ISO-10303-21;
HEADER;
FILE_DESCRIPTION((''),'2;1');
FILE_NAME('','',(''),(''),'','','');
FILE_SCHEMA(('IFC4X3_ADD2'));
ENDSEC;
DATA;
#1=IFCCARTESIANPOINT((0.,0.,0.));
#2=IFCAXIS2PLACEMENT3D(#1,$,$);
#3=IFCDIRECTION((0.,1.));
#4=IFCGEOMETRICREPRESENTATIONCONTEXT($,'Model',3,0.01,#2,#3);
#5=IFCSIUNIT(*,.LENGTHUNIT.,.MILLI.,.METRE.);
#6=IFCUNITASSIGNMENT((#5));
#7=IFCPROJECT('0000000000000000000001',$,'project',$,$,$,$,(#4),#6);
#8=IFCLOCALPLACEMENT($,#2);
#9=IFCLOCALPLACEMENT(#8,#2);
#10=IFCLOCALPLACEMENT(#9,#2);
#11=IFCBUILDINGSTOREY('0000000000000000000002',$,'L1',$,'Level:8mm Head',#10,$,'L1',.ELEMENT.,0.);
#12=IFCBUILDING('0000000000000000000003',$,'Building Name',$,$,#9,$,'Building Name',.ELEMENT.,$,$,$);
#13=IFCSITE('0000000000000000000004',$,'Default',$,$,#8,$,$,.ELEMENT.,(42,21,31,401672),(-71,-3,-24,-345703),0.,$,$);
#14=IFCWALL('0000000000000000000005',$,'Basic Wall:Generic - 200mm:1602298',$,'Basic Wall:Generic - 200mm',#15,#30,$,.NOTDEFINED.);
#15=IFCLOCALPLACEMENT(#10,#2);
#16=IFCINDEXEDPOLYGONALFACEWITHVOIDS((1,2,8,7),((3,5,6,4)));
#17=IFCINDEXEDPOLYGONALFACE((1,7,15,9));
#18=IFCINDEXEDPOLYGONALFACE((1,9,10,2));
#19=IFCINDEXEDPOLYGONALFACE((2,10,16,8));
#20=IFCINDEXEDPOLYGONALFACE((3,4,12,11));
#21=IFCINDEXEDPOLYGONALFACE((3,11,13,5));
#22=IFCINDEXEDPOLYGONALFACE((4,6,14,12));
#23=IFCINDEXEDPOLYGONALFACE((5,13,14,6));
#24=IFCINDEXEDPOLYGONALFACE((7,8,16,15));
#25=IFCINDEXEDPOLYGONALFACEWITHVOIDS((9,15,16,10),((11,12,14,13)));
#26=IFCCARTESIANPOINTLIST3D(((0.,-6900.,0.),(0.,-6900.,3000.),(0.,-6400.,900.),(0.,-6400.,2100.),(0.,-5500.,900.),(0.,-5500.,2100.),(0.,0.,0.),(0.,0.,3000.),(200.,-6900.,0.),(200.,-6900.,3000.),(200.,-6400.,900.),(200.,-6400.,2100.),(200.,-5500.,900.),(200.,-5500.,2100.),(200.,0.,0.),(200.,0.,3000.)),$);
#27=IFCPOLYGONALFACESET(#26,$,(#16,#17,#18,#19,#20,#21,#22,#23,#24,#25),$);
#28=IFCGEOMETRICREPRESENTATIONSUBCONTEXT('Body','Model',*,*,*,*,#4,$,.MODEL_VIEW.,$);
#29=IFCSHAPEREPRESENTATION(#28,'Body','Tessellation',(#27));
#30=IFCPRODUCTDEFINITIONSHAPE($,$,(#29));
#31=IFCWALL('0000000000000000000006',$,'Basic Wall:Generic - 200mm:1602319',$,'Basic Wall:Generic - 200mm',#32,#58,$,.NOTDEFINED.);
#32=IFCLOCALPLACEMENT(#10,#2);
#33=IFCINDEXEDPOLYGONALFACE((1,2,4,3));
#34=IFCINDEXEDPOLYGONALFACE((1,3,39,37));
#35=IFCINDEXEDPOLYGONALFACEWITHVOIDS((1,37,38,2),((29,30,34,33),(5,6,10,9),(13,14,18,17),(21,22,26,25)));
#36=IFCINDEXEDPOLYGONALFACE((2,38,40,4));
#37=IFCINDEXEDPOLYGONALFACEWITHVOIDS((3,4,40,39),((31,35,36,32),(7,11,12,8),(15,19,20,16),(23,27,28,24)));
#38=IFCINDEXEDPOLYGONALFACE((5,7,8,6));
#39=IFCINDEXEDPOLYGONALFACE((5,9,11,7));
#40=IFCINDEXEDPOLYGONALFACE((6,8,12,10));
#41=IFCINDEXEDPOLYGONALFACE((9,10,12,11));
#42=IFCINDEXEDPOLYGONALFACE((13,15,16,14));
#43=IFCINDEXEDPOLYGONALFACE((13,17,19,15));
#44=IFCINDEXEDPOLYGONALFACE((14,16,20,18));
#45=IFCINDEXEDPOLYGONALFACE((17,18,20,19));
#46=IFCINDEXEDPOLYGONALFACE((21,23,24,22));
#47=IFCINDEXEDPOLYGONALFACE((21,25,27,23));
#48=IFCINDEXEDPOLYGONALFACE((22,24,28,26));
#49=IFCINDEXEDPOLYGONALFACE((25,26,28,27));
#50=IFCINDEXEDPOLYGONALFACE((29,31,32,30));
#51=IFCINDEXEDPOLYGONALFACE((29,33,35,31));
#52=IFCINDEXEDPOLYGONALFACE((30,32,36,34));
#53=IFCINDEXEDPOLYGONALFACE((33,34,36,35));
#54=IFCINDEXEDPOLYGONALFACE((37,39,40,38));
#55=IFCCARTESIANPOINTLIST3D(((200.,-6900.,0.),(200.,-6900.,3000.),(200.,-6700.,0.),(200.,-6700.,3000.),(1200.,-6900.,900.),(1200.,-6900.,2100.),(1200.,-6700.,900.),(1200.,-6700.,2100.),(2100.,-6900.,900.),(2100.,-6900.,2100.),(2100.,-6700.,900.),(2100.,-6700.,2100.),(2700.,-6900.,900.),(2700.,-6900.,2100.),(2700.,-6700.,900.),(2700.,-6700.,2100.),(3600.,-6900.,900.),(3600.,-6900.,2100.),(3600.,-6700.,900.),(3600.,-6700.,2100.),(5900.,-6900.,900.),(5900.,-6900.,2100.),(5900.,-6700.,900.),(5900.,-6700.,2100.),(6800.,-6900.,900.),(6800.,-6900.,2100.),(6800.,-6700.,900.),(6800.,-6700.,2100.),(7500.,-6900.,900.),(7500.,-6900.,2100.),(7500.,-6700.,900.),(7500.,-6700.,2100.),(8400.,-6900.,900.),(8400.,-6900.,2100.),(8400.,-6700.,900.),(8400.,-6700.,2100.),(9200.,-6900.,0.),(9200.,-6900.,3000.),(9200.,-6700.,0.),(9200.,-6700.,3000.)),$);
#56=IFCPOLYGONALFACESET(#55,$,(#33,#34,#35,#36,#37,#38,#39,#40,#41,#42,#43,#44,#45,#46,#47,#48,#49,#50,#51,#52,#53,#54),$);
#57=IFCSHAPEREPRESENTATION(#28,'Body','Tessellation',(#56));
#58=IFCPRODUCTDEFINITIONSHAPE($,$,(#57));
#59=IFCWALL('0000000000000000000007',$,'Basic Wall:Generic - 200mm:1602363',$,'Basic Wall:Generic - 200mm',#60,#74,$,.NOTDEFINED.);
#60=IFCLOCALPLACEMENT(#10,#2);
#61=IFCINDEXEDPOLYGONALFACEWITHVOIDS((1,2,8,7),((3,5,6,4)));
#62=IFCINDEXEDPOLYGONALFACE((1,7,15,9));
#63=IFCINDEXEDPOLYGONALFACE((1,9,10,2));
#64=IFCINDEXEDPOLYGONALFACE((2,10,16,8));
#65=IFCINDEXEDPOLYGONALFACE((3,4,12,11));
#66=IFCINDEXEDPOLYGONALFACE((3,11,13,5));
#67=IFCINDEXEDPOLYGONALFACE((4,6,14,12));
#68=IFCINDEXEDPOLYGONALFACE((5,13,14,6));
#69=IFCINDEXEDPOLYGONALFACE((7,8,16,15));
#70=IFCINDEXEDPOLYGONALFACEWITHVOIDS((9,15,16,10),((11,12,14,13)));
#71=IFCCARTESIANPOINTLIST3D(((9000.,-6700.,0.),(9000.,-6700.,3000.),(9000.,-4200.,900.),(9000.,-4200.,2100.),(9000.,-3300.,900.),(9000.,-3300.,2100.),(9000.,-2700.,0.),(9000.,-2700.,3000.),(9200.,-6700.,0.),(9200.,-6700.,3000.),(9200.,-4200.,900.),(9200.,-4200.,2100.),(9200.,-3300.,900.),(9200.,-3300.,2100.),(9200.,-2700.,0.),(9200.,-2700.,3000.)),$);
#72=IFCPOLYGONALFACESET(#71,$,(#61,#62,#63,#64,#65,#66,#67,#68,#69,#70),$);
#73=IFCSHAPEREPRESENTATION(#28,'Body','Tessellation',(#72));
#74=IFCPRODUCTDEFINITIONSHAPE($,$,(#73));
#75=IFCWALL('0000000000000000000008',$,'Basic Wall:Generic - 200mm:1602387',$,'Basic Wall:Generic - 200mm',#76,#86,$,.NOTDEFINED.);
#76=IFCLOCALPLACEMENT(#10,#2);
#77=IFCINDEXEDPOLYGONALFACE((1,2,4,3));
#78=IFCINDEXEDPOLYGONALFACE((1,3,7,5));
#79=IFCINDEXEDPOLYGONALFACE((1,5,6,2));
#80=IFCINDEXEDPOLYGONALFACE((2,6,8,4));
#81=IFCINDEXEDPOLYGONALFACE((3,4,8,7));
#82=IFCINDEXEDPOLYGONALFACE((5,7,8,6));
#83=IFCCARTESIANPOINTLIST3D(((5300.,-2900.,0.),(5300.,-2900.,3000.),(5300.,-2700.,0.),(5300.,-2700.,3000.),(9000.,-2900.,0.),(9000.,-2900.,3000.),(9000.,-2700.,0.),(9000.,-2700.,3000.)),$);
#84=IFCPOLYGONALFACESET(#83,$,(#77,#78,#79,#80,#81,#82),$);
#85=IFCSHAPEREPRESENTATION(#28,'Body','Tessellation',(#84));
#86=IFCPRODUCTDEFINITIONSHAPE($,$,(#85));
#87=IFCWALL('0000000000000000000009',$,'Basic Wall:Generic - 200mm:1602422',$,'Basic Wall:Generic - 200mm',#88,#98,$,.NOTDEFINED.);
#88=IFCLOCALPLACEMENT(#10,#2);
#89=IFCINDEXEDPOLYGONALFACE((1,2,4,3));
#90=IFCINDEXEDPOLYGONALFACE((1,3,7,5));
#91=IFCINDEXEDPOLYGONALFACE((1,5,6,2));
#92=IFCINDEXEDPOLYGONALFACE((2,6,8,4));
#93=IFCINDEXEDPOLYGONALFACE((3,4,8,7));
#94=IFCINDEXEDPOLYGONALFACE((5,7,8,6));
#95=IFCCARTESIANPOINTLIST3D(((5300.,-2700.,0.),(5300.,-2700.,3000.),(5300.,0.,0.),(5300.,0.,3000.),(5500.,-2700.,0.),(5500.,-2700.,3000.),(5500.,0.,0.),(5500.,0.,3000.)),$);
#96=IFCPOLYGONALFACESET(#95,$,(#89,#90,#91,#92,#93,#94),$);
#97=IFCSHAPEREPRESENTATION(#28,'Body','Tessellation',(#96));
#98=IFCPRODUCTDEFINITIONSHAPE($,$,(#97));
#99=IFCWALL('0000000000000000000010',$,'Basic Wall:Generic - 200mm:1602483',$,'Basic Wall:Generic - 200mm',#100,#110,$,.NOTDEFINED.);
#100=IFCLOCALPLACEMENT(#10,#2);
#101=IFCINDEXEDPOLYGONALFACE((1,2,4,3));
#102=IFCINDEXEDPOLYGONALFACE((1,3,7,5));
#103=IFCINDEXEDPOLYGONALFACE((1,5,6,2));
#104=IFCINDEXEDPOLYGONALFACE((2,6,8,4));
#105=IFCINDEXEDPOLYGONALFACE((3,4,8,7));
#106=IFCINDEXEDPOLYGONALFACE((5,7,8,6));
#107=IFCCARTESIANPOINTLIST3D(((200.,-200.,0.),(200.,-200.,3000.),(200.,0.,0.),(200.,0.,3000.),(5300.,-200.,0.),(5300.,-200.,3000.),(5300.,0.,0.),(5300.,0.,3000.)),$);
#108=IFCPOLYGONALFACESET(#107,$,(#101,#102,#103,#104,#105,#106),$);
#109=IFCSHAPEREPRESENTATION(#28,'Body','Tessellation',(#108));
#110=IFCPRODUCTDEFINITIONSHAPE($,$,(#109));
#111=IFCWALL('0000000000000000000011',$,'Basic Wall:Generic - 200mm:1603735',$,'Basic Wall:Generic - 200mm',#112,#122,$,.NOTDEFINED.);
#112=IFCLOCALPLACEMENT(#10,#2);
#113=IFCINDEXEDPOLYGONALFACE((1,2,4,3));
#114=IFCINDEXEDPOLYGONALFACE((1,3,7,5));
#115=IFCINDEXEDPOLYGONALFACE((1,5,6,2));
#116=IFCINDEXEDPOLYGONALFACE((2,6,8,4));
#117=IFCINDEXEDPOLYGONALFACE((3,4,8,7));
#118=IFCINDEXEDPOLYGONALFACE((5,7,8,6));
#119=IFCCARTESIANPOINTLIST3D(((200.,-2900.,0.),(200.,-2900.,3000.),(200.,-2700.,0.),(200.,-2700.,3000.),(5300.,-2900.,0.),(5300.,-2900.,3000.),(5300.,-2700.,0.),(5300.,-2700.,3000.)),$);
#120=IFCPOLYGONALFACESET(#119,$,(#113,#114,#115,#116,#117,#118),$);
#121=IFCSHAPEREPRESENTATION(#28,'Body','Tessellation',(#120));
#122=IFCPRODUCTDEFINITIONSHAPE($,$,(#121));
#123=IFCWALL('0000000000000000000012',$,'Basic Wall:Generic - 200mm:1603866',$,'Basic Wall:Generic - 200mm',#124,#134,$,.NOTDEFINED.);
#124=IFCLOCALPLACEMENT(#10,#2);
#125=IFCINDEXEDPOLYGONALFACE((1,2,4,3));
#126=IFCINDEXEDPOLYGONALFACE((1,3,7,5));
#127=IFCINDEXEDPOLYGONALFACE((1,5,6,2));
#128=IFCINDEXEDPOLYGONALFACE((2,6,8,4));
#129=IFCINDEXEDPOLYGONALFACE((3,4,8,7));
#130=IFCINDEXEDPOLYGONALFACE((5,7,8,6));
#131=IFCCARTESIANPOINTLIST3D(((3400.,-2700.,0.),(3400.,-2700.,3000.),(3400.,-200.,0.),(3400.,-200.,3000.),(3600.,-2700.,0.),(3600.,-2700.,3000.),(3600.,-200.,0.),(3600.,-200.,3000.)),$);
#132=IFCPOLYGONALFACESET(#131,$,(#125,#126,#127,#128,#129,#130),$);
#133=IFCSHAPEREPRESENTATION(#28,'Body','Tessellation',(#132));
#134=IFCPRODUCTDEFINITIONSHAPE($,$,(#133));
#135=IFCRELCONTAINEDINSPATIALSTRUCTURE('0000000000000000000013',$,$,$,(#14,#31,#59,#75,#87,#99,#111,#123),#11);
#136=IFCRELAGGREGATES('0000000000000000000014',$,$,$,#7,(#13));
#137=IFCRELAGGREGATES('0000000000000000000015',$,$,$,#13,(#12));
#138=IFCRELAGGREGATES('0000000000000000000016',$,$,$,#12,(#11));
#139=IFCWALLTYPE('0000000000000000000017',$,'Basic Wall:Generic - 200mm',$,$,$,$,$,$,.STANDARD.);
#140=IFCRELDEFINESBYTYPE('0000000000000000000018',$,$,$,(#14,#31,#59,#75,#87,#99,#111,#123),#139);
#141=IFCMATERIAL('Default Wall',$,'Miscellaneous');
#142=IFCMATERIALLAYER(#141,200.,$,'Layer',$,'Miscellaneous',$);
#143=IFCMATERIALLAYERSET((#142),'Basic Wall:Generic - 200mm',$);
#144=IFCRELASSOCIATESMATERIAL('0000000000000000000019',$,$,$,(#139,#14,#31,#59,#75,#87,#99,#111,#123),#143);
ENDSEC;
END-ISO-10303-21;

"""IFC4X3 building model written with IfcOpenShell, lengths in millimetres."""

from ifc_helpers import new_model, si_unit, direction, frame, frame_2d, origin, place, context, subcontext, project, spatial, rectangle, extrude, material, layer, layer_set, type_object, element, save


model = new_model("IFC4X3")

# Units and contexts
model_context = context("Model", 3, precision=0.01, world=origin(), true_north=direction((0.0, 1.0)))
body_context = subcontext(model_context, "Body", "Model", "MODEL_VIEW")
ifc_project = project(units=[si_unit("LENGTHUNIT", "METRE", prefix="MILLI")], contexts=[model_context])

# Site, building, storey
site_placement = place(None, origin())
site = spatial("IfcSite", under=ifc_project, at=site_placement, Name="Default", CompositionType="ELEMENT", RefLatitude=(42, 21, 31, 401672), RefLongitude=(-71, -3, -24, -345703), RefElevation=0.0)
building_placement = place(site_placement, origin())
building = spatial("IfcBuilding", under=site, at=building_placement, Name="Building Name", LongName="Building Name", CompositionType="ELEMENT")
storey_placement = place(building_placement, origin())
storey = spatial("IfcBuildingStorey", under=building, at=storey_placement, Name="L1", ObjectType="Level:8mm Head", LongName="L1", CompositionType="ELEMENT", Elevation=0.0)

# Wall, opening
ifc_material = material(Name="Default Wall", Category="Miscellaneous")
ifc_layer = layer(ifc_material, 200.0, Name="Layer", Category="Miscellaneous")
ifc_layer_set = layer_set([ifc_layer], Name="Basic Wall:Generic - 200mm")
wall_type = type_object("IfcWallType", Name="Basic Wall:Generic - 200mm", PredefinedType="STANDARD", material=ifc_layer_set)
wall_1_placement = place(storey_placement, frame((100.0, 0.0, 0.0), z_axis=(0.0, 0.0, 1.0), x_axis=(0.0, -1.0, 0.0)))
wall_1 = element("IfcWall", 1, at=wall_1_placement, inside=storey, type_object=wall_type, material=ifc_layer_set, Name="Basic Wall:Generic - 200mm:1602298", ObjectType="Basic Wall:Generic - 200mm", PredefinedType="NOTDEFINED", context=body_context, shape_type="SweptSolid", body=[
    extrude(rectangle(XDim=6900.0, YDim=200.0, at=frame_2d((3450.0, 0.0), x_axis=(-1.0, 0.0))), origin(), (0.0, 0.0, 1.0), 3000.0),
])
opening_1_placement = place(wall_1_placement, frame((6400.0, 100.0, 900.0)))
element("IfcOpeningElement", 2, at=opening_1_placement, cuts=wall_1, PredefinedType="OPENING", context=body_context, shape_type="SweptSolid", body=[
    extrude(rectangle(XDim=1200.0, YDim=900.0, at=frame_2d((600.0, 450.0), x_axis=(-1.0, 0.0))), frame((0.0, 0.0, 0.0), z_axis=(0.0, -1.0, 0.0), x_axis=(0.0, 0.0, 1.0)), (0.0, 0.0, 1.0), 200.0),
])

# Wall, openings
wall_2_placement = place(storey_placement, frame((200.0, -6800.0, 0.0)))
wall_2 = element("IfcWall", 3, at=wall_2_placement, inside=storey, type_object=wall_type, material=ifc_layer_set, Name="Basic Wall:Generic - 200mm:1602319", ObjectType="Basic Wall:Generic - 200mm", PredefinedType="NOTDEFINED", context=body_context, shape_type="SweptSolid", body=[
    extrude(rectangle(XDim=9000.0, YDim=200.0, at=frame_2d((4500.0, 0.0), x_axis=(-1.0, 0.0))), origin(), (0.0, 0.0, 1.0), 3000.0),
])
opening_2_placement = place(wall_2_placement, frame((1900.0, 100.0, 900.0)))
element("IfcOpeningElement", 4, at=opening_2_placement, cuts=wall_2, PredefinedType="OPENING", context=body_context, shape_type="SweptSolid", body=[
    extrude(rectangle(XDim=1200.0, YDim=900.0, at=frame_2d((600.0, 450.0), x_axis=(-1.0, 0.0))), frame((0.0, 0.0, 0.0), z_axis=(0.0, -1.0, 0.0), x_axis=(0.0, 0.0, 1.0)), (0.0, 0.0, 1.0), 200.0),
])
opening_3_placement = place(wall_2_placement, frame((3400.0, 100.0, 900.0)))
element("IfcOpeningElement", 5, at=opening_3_placement, cuts=wall_2, PredefinedType="OPENING", context=body_context, shape_type="SweptSolid", body=[
    extrude(rectangle(XDim=1200.0, YDim=900.0, at=frame_2d((600.0, 450.0), x_axis=(-1.0, 0.0))), frame((0.0, 0.0, 0.0), z_axis=(0.0, -1.0, 0.0), x_axis=(0.0, 0.0, 1.0)), (0.0, 0.0, 1.0), 200.0),
])
opening_4_placement = place(wall_2_placement, frame((8200.0, 100.0, 900.0)))
element("IfcOpeningElement", 6, at=opening_4_placement, cuts=wall_2, PredefinedType="OPENING", context=body_context, shape_type="SweptSolid", body=[
    extrude(rectangle(XDim=1200.0, YDim=900.0, at=frame_2d((600.0, 450.0), x_axis=(-1.0, 0.0))), frame((0.0, 0.0, 0.0), z_axis=(0.0, -1.0, 0.0), x_axis=(0.0, 0.0, 1.0)), (0.0, 0.0, 1.0), 200.0),
])
opening_5_placement = place(wall_2_placement, frame((6600.0, 100.0, 900.0)))
element("IfcOpeningElement", 7, at=opening_5_placement, cuts=wall_2, PredefinedType="OPENING", context=body_context, shape_type="SweptSolid", body=[
    extrude(rectangle(XDim=1200.0, YDim=900.0, at=frame_2d((600.0, 450.0), x_axis=(-1.0, 0.0))), frame((0.0, 0.0, 0.0), z_axis=(0.0, -1.0, 0.0), x_axis=(0.0, 0.0, 1.0)), (0.0, 0.0, 1.0), 200.0),
])

# Wall, opening
wall_3_placement = place(storey_placement, frame((9100.0, -6700.0, 0.0), z_axis=(0.0, 0.0, 1.0), x_axis=(0.0, 1.0, 0.0)))
wall_3 = element("IfcWall", 8, at=wall_3_placement, inside=storey, type_object=wall_type, material=ifc_layer_set, Name="Basic Wall:Generic - 200mm:1602363", ObjectType="Basic Wall:Generic - 200mm", PredefinedType="NOTDEFINED", context=body_context, shape_type="SweptSolid", body=[
    extrude(rectangle(XDim=4000.0, YDim=200.0, at=frame_2d((2000.0, 0.0), x_axis=(-1.0, 0.0))), origin(), (0.0, 0.0, 1.0), 3000.0),
])
opening_6_placement = place(wall_3_placement, frame((3400.0, 100.0, 900.0)))
element("IfcOpeningElement", 9, at=opening_6_placement, cuts=wall_3, PredefinedType="OPENING", context=body_context, shape_type="SweptSolid", body=[
    extrude(rectangle(XDim=1200.0, YDim=900.0, at=frame_2d((600.0, 450.0), x_axis=(-1.0, 0.0))), frame((0.0, 0.0, 0.0), z_axis=(0.0, -1.0, 0.0), x_axis=(0.0, 0.0, 1.0)), (0.0, 0.0, 1.0), 200.0),
])

# Walls
wall_4_placement = place(storey_placement, frame((9000.0, -2800.0, 0.0), z_axis=(0.0, 0.0, 1.0), x_axis=(-1.0, 0.0, 0.0)))
element("IfcWall", 10, at=wall_4_placement, inside=storey, type_object=wall_type, material=ifc_layer_set, Name="Basic Wall:Generic - 200mm:1602387", ObjectType="Basic Wall:Generic - 200mm", PredefinedType="NOTDEFINED", context=body_context, shape_type="SweptSolid", body=[
    extrude(rectangle(XDim=3700.0, YDim=200.0, at=frame_2d((1850.0, 0.0), x_axis=(-1.0, 0.0))), origin(), (0.0, 0.0, 1.0), 3000.0),
])
wall_5_placement = place(storey_placement, frame((5400.0, -2700.0, 0.0), z_axis=(0.0, 0.0, 1.0), x_axis=(0.0, 1.0, 0.0)))
element("IfcWall", 11, at=wall_5_placement, inside=storey, type_object=wall_type, material=ifc_layer_set, Name="Basic Wall:Generic - 200mm:1602422", ObjectType="Basic Wall:Generic - 200mm", PredefinedType="NOTDEFINED", context=body_context, shape_type="SweptSolid", body=[
    extrude(rectangle(XDim=2700.0, YDim=200.0, at=frame_2d((1350.0, 0.0), x_axis=(-1.0, 0.0))), origin(), (0.0, 0.0, 1.0), 3000.0),
])
wall_6_placement = place(storey_placement, frame((5300.0, -100.0, 0.0), z_axis=(0.0, 0.0, 1.0), x_axis=(-1.0, 0.0, 0.0)))
element("IfcWall", 12, at=wall_6_placement, inside=storey, type_object=wall_type, material=ifc_layer_set, Name="Basic Wall:Generic - 200mm:1602483", ObjectType="Basic Wall:Generic - 200mm", PredefinedType="NOTDEFINED", context=body_context, shape_type="SweptSolid", body=[
    extrude(rectangle(XDim=5100.0, YDim=200.0, at=frame_2d((2550.0, 0.0), x_axis=(-1.0, 0.0))), origin(), (0.0, 0.0, 1.0), 3000.0),
])
wall_7_placement = place(storey_placement, frame((200.0, -2800.0, 0.0)))
element("IfcWall", 13, at=wall_7_placement, inside=storey, type_object=wall_type, material=ifc_layer_set, Name="Basic Wall:Generic - 200mm:1603735", ObjectType="Basic Wall:Generic - 200mm", PredefinedType="NOTDEFINED", context=body_context, shape_type="SweptSolid", body=[
    extrude(rectangle(XDim=5100.0, YDim=200.0, at=frame_2d((2550.0, 0.0), x_axis=(-1.0, 0.0))), origin(), (0.0, 0.0, 1.0), 3000.0),
])
wall_8_placement = place(storey_placement, frame((3500.0, -2700.0, 0.0), z_axis=(0.0, 0.0, 1.0), x_axis=(0.0, 1.0, 0.0)))
element("IfcWall", 14, at=wall_8_placement, inside=storey, type_object=wall_type, material=ifc_layer_set, Name="Basic Wall:Generic - 200mm:1603866", ObjectType="Basic Wall:Generic - 200mm", PredefinedType="NOTDEFINED", context=body_context, shape_type="SweptSolid", body=[
    extrude(rectangle(XDim=2500.0, YDim=200.0, at=frame_2d((1250.0, 0.0), x_axis=(-1.0, 0.0))), origin(), (0.0, 0.0, 1.0), 3000.0),
])

save(model, "model.ifc")
